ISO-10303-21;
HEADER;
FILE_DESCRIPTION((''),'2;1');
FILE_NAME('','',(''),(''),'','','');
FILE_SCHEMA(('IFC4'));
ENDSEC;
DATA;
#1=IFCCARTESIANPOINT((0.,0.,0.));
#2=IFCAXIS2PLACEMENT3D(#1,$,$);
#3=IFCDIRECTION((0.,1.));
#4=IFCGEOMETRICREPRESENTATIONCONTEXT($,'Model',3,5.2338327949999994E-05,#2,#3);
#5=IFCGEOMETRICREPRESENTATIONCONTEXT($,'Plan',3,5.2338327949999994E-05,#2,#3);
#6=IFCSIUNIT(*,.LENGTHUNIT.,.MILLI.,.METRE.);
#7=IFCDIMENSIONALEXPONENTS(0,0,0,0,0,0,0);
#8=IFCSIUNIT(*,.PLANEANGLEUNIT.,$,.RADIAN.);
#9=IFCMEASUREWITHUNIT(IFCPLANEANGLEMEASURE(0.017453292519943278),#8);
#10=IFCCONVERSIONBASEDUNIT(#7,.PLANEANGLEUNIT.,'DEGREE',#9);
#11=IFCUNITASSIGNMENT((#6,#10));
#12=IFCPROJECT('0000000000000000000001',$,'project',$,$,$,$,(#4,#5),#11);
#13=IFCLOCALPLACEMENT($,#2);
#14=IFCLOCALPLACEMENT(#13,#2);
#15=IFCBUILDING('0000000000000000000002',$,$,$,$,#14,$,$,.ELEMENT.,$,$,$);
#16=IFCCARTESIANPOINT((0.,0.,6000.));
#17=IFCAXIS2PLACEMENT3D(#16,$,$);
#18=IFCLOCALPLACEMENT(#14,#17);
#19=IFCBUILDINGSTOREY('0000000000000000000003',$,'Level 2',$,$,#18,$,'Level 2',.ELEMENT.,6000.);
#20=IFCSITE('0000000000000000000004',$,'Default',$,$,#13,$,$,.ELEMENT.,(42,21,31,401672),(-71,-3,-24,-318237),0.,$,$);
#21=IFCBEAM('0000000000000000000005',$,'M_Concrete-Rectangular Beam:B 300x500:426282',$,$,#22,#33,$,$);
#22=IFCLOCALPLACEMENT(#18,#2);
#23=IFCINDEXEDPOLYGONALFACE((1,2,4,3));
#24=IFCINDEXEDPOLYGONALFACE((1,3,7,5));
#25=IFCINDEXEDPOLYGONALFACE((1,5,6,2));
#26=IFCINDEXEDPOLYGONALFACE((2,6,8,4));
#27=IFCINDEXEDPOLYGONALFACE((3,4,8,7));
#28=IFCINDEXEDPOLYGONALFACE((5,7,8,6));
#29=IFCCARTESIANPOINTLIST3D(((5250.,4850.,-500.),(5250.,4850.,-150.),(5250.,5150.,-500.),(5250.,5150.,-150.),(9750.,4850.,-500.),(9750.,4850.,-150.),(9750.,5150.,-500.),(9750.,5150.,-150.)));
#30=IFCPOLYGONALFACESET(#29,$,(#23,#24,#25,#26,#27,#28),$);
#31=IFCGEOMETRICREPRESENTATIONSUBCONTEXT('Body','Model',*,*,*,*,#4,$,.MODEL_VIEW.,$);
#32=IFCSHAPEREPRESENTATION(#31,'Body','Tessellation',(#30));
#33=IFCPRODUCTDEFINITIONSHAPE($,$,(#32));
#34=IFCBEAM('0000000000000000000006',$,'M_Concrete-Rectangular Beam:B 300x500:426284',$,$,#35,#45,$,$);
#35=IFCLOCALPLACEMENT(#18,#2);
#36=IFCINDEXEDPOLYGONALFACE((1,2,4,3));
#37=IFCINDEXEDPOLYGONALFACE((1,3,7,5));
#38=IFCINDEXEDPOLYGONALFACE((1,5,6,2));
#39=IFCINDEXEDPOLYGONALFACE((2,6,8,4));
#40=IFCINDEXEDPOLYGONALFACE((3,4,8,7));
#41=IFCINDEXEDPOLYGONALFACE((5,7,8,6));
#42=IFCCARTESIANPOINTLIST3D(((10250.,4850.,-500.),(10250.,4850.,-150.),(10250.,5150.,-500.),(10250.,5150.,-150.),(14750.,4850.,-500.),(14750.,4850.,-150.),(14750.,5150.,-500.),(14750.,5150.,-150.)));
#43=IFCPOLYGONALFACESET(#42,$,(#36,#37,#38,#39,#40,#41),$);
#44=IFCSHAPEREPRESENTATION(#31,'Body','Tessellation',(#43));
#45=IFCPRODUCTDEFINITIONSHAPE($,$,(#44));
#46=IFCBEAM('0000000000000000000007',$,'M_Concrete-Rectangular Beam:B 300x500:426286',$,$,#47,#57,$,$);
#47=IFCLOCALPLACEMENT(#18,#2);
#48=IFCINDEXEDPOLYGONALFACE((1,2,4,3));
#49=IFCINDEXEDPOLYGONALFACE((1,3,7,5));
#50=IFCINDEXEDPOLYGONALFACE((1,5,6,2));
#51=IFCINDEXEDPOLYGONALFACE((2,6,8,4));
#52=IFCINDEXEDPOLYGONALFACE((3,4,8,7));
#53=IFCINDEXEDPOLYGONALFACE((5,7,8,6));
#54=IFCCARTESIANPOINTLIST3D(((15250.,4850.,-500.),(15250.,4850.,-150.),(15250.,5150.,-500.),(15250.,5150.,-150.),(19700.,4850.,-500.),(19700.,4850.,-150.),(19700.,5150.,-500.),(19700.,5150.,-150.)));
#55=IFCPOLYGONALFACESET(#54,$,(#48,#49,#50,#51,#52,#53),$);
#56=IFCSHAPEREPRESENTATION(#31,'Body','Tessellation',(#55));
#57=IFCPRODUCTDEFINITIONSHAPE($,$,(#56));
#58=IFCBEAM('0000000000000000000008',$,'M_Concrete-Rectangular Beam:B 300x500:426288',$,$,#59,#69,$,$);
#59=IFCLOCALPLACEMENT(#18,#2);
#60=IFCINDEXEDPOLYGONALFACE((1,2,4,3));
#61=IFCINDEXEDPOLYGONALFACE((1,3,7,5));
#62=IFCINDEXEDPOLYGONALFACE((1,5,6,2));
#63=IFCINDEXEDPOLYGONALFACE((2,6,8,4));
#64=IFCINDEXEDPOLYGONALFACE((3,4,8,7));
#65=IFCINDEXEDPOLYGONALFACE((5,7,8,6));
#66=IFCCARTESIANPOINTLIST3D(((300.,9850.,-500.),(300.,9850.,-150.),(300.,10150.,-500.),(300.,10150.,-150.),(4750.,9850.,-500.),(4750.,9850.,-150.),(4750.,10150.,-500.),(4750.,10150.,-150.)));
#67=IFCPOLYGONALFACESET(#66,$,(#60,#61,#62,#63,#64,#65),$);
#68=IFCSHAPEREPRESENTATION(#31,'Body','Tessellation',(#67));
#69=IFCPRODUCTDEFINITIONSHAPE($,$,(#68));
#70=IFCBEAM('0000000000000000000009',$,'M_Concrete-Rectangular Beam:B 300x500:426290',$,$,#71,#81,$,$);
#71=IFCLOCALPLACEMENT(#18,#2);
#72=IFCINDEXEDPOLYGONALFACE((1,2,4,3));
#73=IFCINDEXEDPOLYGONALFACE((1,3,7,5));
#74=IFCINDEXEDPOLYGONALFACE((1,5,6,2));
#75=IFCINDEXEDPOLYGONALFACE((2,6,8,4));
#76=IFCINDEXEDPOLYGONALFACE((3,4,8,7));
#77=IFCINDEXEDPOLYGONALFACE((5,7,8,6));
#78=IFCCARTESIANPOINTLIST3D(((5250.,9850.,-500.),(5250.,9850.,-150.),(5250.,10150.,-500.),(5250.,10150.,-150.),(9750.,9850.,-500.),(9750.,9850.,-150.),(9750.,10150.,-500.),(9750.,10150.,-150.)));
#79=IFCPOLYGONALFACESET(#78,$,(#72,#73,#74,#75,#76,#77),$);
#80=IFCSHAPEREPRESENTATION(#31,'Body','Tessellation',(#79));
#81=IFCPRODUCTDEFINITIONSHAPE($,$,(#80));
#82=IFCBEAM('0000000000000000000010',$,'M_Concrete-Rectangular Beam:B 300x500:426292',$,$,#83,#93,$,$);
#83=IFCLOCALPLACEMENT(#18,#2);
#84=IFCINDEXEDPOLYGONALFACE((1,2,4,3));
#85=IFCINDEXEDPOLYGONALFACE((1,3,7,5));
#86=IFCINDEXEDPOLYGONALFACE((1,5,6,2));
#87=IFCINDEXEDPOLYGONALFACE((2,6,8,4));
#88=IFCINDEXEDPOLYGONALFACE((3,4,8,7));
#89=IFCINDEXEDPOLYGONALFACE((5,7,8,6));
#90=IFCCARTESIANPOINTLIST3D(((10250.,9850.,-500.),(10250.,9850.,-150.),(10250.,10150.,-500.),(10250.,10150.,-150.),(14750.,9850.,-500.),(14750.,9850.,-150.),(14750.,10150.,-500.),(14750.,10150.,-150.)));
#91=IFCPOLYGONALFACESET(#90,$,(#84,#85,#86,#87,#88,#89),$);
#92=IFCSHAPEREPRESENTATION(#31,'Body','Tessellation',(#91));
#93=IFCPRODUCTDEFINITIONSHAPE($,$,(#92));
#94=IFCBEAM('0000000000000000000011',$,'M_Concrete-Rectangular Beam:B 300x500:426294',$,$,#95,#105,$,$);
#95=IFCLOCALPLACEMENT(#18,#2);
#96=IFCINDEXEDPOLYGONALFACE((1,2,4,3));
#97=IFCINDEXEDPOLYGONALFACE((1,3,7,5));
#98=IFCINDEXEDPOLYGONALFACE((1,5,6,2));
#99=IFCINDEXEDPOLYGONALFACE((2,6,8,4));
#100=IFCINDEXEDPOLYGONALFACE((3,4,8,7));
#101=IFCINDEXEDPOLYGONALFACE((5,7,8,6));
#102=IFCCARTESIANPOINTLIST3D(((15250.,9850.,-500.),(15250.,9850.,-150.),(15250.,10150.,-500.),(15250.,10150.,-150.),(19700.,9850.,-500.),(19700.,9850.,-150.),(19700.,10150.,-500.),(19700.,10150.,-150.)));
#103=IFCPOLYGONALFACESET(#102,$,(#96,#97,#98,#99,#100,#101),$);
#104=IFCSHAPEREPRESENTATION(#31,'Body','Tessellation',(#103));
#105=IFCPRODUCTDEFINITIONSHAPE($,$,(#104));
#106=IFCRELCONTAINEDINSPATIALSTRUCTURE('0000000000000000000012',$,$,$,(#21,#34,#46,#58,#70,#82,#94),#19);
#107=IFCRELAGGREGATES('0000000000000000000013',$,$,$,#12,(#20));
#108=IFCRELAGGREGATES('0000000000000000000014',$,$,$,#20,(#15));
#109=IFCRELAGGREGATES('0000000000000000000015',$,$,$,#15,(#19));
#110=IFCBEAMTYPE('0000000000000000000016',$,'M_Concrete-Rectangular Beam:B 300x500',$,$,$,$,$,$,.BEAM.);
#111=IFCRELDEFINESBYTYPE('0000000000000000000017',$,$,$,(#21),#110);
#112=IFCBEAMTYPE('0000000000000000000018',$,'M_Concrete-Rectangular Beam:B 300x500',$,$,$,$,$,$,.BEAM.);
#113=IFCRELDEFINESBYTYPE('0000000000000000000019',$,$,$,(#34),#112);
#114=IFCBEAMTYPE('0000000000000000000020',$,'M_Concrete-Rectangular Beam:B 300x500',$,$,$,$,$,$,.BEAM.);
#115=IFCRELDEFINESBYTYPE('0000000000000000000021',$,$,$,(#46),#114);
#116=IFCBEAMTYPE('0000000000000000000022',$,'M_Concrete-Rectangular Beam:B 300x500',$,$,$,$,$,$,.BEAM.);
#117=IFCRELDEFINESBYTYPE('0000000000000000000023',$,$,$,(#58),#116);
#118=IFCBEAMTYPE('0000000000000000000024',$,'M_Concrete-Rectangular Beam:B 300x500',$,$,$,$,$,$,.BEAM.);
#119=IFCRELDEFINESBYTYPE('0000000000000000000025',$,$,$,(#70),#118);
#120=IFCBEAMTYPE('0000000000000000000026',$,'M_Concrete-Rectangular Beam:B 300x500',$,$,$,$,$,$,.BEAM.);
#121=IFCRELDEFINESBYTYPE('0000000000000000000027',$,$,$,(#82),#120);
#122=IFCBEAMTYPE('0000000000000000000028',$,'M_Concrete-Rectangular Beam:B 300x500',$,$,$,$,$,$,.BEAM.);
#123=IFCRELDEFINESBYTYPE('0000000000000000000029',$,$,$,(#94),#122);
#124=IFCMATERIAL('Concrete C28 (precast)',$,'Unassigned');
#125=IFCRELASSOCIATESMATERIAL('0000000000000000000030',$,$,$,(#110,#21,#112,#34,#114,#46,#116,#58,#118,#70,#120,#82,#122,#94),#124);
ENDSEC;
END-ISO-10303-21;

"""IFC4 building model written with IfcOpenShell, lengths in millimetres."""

from ifc_helpers import new_model, entity, si_unit, converted_unit, direction, frame, origin, place, context, subcontext, project, spatial, indexed_curve, outline, extrude, source, transform, mapped, material, type_object, type_shapes, element, save


model = new_model("IFC4")

# Units and contexts
model_context = context("Model", 3, precision=5.2338327949999994e-05, world=origin(), true_north=direction((0.0, 1.0)))
plan_context = context("Plan", 3, precision=5.2338327949999994e-05, world=origin(), true_north=direction((0.0, 1.0)))
body_context = subcontext(model_context, "Body", "Model", "MODEL_VIEW")
ifc_project = project(units=[si_unit("LENGTHUNIT", "METRE", prefix="MILLI"), converted_unit("PLANEANGLEUNIT", "DEGREE", entity("IfcPlaneAngleMeasure", 0.017453292519943278), si_unit("PLANEANGLEUNIT", "RADIAN"), dimensions=[0, 0, 0, 0, 0, 0, 0])], contexts=[model_context, plan_context])

# Site, building, storey
site_placement = place(None, origin())
site = spatial("IfcSite", under=ifc_project, at=site_placement, Name="Default", CompositionType="ELEMENT", RefLatitude=(42, 21, 31, 401672), RefLongitude=(-71, -3, -24, -318237), RefElevation=0.0)
building_placement = place(site_placement, origin())
building = spatial("IfcBuilding", under=site, at=building_placement, CompositionType="ELEMENT")
storey_placement = place(building_placement, frame((0.0, 0.0, 6000.0)))
storey = spatial("IfcBuildingStorey", under=building, at=storey_placement, Name="Level 2", LongName="Level 2", CompositionType="ELEMENT", Elevation=6000.0)

# Shared definitions
ifc_material = material(Name="Concrete C28 (precast)", Category="Unassigned")

# Beams
beam_type_1 = type_object("IfcBeamType", Name="M_Concrete-Rectangular Beam:B 300x500", PredefinedType="BEAM", material=ifc_material)
shared_shape_1 = source(origin(), body_context, "Body", "SweptSolid", [
    extrude(outline(indexed_curve([(-175.0, -150.0), (175.0, -150.0), (175.0, 150.0), (-175.0, 150.0), (-175.0, -150.0)], self_intersect=False)), frame((5250.0, 5000.0, 5675.0), z_axis=(1.0, 0.0, 0.0), x_axis=(0.0, 0.0, -1.0)), (0.0, 0.0, 1.0), 4500.0),
])
type_shapes(beam_type_1, [shared_shape_1])
beam_1_placement = place(storey_placement, frame((0.0, 0.0, -6000.0)))
element("IfcBeam", 1, at=beam_1_placement, inside=storey, type_object=beam_type_1, material=ifc_material, Name="M_Concrete-Rectangular Beam:B 300x500:426282", context=body_context, shape_type="MappedRepresentation", body=[
    mapped(shared_shape_1, transform((0.0, 0.0, 0.0), scale=1.0)),
])
beam_type_2 = type_object("IfcBeamType", Name="M_Concrete-Rectangular Beam:B 300x500", PredefinedType="BEAM", material=ifc_material)
shared_shape_2 = source(origin(), body_context, "Body", "SweptSolid", [
    extrude(outline(indexed_curve([(-175.0, -150.0), (175.0, -150.0), (175.0, 150.0), (-175.0, 150.0), (-175.0, -150.0)], self_intersect=False)), frame((10250.0, 5000.0, 5675.0), z_axis=(1.0, 0.0, 0.0), x_axis=(0.0, 0.0, -1.0)), (0.0, 0.0, 1.0), 4500.0),
])
type_shapes(beam_type_2, [shared_shape_2])
beam_2_placement = place(storey_placement, frame((0.0, 0.0, -6000.0)))
element("IfcBeam", 2, at=beam_2_placement, inside=storey, type_object=beam_type_2, material=ifc_material, Name="M_Concrete-Rectangular Beam:B 300x500:426284", context=body_context, shape_type="MappedRepresentation", body=[
    mapped(shared_shape_2, transform((0.0, 0.0, 0.0), scale=1.0)),
])
beam_type_3 = type_object("IfcBeamType", Name="M_Concrete-Rectangular Beam:B 300x500", PredefinedType="BEAM", material=ifc_material)
shared_shape_3 = source(origin(), body_context, "Body", "SweptSolid", [
    extrude(outline(indexed_curve([(-175.0, -150.0), (175.0, -150.0), (175.0, 150.0), (-175.0, 150.0), (-175.0, -150.0)], self_intersect=False)), frame((15250.0, 5000.0, 5675.0), z_axis=(1.0, 0.0, 0.0), x_axis=(0.0, 0.0, -1.0)), (0.0, 0.0, 1.0), 4450.0),
])
type_shapes(beam_type_3, [shared_shape_3])
beam_3_placement = place(storey_placement, frame((0.0, 0.0, -6000.0)))
element("IfcBeam", 3, at=beam_3_placement, inside=storey, type_object=beam_type_3, material=ifc_material, Name="M_Concrete-Rectangular Beam:B 300x500:426286", context=body_context, shape_type="MappedRepresentation", body=[
    mapped(shared_shape_3, transform((0.0, 0.0, 0.0), scale=1.0)),
])
beam_type_4 = type_object("IfcBeamType", Name="M_Concrete-Rectangular Beam:B 300x500", PredefinedType="BEAM", material=ifc_material)
shared_shape_4 = source(origin(), body_context, "Body", "SweptSolid", [
    extrude(outline(indexed_curve([(-175.0, -150.0), (175.0, -150.0), (175.0, 150.0), (-175.0, 150.0), (-175.0, -150.0)], self_intersect=False)), frame((300.0, 10000.0, 5675.0), z_axis=(1.0, 0.0, 0.0), x_axis=(0.0, 0.0, -1.0)), (0.0, 0.0, 1.0), 4450.0),
])
type_shapes(beam_type_4, [shared_shape_4])
beam_4_placement = place(storey_placement, frame((0.0, 0.0, -6000.0)))
element("IfcBeam", 4, at=beam_4_placement, inside=storey, type_object=beam_type_4, material=ifc_material, Name="M_Concrete-Rectangular Beam:B 300x500:426288", context=body_context, shape_type="MappedRepresentation", body=[
    mapped(shared_shape_4, transform((0.0, 0.0, 0.0), scale=1.0)),
])
beam_type_5 = type_object("IfcBeamType", Name="M_Concrete-Rectangular Beam:B 300x500", PredefinedType="BEAM", material=ifc_material)
shared_shape_5 = source(origin(), body_context, "Body", "SweptSolid", [
    extrude(outline(indexed_curve([(-175.0, -150.0), (175.0, -150.0), (175.0, 150.0), (-175.0, 150.0), (-175.0, -150.0)], self_intersect=False)), frame((5250.0, 10000.0, 5675.0), z_axis=(1.0, 0.0, 0.0), x_axis=(0.0, 0.0, -1.0)), (0.0, 0.0, 1.0), 4500.0),
])
type_shapes(beam_type_5, [shared_shape_5])
beam_5_placement = place(storey_placement, frame((0.0, 0.0, -6000.0)))
element("IfcBeam", 5, at=beam_5_placement, inside=storey, type_object=beam_type_5, material=ifc_material, Name="M_Concrete-Rectangular Beam:B 300x500:426290", context=body_context, shape_type="MappedRepresentation", body=[
    mapped(shared_shape_5, transform((0.0, 0.0, 0.0), scale=1.0)),
])
beam_type_6 = type_object("IfcBeamType", Name="M_Concrete-Rectangular Beam:B 300x500", PredefinedType="BEAM", material=ifc_material)
shared_shape_6 = source(origin(), body_context, "Body", "SweptSolid", [
    extrude(outline(indexed_curve([(-175.0, -150.0), (175.0, -150.0), (175.0, 150.0), (-175.0, 150.0), (-175.0, -150.0)], self_intersect=False)), frame((10250.0, 10000.0, 5675.0), z_axis=(1.0, 0.0, 0.0), x_axis=(0.0, 0.0, -1.0)), (0.0, 0.0, 1.0), 4500.0),
])
type_shapes(beam_type_6, [shared_shape_6])
beam_6_placement = place(storey_placement, frame((0.0, 0.0, -6000.0)))
element("IfcBeam", 6, at=beam_6_placement, inside=storey, type_object=beam_type_6, material=ifc_material, Name="M_Concrete-Rectangular Beam:B 300x500:426292", context=body_context, shape_type="MappedRepresentation", body=[
    mapped(shared_shape_6, transform((0.0, 0.0, 0.0), scale=1.0)),
])
beam_type_7 = type_object("IfcBeamType", Name="M_Concrete-Rectangular Beam:B 300x500", PredefinedType="BEAM", material=ifc_material)
shared_shape_7 = source(origin(), body_context, "Body", "SweptSolid", [
    extrude(outline(indexed_curve([(-175.0, -150.0), (175.0, -150.0), (175.0, 150.0), (-175.0, 150.0), (-175.0, -150.0)], self_intersect=False)), frame((15250.0, 10000.0, 5675.0), z_axis=(1.0, 0.0, 0.0), x_axis=(0.0, 0.0, -1.0)), (0.0, 0.0, 1.0), 4450.0),
])
type_shapes(beam_type_7, [shared_shape_7])
beam_7_placement = place(storey_placement, frame((0.0, 0.0, -6000.0)))
element("IfcBeam", 7, at=beam_7_placement, inside=storey, type_object=beam_type_7, material=ifc_material, Name="M_Concrete-Rectangular Beam:B 300x500:426294", context=body_context, shape_type="MappedRepresentation", body=[
    mapped(shared_shape_7, transform((0.0, 0.0, 0.0), scale=1.0)),
])

save(model, "model.ifc")
